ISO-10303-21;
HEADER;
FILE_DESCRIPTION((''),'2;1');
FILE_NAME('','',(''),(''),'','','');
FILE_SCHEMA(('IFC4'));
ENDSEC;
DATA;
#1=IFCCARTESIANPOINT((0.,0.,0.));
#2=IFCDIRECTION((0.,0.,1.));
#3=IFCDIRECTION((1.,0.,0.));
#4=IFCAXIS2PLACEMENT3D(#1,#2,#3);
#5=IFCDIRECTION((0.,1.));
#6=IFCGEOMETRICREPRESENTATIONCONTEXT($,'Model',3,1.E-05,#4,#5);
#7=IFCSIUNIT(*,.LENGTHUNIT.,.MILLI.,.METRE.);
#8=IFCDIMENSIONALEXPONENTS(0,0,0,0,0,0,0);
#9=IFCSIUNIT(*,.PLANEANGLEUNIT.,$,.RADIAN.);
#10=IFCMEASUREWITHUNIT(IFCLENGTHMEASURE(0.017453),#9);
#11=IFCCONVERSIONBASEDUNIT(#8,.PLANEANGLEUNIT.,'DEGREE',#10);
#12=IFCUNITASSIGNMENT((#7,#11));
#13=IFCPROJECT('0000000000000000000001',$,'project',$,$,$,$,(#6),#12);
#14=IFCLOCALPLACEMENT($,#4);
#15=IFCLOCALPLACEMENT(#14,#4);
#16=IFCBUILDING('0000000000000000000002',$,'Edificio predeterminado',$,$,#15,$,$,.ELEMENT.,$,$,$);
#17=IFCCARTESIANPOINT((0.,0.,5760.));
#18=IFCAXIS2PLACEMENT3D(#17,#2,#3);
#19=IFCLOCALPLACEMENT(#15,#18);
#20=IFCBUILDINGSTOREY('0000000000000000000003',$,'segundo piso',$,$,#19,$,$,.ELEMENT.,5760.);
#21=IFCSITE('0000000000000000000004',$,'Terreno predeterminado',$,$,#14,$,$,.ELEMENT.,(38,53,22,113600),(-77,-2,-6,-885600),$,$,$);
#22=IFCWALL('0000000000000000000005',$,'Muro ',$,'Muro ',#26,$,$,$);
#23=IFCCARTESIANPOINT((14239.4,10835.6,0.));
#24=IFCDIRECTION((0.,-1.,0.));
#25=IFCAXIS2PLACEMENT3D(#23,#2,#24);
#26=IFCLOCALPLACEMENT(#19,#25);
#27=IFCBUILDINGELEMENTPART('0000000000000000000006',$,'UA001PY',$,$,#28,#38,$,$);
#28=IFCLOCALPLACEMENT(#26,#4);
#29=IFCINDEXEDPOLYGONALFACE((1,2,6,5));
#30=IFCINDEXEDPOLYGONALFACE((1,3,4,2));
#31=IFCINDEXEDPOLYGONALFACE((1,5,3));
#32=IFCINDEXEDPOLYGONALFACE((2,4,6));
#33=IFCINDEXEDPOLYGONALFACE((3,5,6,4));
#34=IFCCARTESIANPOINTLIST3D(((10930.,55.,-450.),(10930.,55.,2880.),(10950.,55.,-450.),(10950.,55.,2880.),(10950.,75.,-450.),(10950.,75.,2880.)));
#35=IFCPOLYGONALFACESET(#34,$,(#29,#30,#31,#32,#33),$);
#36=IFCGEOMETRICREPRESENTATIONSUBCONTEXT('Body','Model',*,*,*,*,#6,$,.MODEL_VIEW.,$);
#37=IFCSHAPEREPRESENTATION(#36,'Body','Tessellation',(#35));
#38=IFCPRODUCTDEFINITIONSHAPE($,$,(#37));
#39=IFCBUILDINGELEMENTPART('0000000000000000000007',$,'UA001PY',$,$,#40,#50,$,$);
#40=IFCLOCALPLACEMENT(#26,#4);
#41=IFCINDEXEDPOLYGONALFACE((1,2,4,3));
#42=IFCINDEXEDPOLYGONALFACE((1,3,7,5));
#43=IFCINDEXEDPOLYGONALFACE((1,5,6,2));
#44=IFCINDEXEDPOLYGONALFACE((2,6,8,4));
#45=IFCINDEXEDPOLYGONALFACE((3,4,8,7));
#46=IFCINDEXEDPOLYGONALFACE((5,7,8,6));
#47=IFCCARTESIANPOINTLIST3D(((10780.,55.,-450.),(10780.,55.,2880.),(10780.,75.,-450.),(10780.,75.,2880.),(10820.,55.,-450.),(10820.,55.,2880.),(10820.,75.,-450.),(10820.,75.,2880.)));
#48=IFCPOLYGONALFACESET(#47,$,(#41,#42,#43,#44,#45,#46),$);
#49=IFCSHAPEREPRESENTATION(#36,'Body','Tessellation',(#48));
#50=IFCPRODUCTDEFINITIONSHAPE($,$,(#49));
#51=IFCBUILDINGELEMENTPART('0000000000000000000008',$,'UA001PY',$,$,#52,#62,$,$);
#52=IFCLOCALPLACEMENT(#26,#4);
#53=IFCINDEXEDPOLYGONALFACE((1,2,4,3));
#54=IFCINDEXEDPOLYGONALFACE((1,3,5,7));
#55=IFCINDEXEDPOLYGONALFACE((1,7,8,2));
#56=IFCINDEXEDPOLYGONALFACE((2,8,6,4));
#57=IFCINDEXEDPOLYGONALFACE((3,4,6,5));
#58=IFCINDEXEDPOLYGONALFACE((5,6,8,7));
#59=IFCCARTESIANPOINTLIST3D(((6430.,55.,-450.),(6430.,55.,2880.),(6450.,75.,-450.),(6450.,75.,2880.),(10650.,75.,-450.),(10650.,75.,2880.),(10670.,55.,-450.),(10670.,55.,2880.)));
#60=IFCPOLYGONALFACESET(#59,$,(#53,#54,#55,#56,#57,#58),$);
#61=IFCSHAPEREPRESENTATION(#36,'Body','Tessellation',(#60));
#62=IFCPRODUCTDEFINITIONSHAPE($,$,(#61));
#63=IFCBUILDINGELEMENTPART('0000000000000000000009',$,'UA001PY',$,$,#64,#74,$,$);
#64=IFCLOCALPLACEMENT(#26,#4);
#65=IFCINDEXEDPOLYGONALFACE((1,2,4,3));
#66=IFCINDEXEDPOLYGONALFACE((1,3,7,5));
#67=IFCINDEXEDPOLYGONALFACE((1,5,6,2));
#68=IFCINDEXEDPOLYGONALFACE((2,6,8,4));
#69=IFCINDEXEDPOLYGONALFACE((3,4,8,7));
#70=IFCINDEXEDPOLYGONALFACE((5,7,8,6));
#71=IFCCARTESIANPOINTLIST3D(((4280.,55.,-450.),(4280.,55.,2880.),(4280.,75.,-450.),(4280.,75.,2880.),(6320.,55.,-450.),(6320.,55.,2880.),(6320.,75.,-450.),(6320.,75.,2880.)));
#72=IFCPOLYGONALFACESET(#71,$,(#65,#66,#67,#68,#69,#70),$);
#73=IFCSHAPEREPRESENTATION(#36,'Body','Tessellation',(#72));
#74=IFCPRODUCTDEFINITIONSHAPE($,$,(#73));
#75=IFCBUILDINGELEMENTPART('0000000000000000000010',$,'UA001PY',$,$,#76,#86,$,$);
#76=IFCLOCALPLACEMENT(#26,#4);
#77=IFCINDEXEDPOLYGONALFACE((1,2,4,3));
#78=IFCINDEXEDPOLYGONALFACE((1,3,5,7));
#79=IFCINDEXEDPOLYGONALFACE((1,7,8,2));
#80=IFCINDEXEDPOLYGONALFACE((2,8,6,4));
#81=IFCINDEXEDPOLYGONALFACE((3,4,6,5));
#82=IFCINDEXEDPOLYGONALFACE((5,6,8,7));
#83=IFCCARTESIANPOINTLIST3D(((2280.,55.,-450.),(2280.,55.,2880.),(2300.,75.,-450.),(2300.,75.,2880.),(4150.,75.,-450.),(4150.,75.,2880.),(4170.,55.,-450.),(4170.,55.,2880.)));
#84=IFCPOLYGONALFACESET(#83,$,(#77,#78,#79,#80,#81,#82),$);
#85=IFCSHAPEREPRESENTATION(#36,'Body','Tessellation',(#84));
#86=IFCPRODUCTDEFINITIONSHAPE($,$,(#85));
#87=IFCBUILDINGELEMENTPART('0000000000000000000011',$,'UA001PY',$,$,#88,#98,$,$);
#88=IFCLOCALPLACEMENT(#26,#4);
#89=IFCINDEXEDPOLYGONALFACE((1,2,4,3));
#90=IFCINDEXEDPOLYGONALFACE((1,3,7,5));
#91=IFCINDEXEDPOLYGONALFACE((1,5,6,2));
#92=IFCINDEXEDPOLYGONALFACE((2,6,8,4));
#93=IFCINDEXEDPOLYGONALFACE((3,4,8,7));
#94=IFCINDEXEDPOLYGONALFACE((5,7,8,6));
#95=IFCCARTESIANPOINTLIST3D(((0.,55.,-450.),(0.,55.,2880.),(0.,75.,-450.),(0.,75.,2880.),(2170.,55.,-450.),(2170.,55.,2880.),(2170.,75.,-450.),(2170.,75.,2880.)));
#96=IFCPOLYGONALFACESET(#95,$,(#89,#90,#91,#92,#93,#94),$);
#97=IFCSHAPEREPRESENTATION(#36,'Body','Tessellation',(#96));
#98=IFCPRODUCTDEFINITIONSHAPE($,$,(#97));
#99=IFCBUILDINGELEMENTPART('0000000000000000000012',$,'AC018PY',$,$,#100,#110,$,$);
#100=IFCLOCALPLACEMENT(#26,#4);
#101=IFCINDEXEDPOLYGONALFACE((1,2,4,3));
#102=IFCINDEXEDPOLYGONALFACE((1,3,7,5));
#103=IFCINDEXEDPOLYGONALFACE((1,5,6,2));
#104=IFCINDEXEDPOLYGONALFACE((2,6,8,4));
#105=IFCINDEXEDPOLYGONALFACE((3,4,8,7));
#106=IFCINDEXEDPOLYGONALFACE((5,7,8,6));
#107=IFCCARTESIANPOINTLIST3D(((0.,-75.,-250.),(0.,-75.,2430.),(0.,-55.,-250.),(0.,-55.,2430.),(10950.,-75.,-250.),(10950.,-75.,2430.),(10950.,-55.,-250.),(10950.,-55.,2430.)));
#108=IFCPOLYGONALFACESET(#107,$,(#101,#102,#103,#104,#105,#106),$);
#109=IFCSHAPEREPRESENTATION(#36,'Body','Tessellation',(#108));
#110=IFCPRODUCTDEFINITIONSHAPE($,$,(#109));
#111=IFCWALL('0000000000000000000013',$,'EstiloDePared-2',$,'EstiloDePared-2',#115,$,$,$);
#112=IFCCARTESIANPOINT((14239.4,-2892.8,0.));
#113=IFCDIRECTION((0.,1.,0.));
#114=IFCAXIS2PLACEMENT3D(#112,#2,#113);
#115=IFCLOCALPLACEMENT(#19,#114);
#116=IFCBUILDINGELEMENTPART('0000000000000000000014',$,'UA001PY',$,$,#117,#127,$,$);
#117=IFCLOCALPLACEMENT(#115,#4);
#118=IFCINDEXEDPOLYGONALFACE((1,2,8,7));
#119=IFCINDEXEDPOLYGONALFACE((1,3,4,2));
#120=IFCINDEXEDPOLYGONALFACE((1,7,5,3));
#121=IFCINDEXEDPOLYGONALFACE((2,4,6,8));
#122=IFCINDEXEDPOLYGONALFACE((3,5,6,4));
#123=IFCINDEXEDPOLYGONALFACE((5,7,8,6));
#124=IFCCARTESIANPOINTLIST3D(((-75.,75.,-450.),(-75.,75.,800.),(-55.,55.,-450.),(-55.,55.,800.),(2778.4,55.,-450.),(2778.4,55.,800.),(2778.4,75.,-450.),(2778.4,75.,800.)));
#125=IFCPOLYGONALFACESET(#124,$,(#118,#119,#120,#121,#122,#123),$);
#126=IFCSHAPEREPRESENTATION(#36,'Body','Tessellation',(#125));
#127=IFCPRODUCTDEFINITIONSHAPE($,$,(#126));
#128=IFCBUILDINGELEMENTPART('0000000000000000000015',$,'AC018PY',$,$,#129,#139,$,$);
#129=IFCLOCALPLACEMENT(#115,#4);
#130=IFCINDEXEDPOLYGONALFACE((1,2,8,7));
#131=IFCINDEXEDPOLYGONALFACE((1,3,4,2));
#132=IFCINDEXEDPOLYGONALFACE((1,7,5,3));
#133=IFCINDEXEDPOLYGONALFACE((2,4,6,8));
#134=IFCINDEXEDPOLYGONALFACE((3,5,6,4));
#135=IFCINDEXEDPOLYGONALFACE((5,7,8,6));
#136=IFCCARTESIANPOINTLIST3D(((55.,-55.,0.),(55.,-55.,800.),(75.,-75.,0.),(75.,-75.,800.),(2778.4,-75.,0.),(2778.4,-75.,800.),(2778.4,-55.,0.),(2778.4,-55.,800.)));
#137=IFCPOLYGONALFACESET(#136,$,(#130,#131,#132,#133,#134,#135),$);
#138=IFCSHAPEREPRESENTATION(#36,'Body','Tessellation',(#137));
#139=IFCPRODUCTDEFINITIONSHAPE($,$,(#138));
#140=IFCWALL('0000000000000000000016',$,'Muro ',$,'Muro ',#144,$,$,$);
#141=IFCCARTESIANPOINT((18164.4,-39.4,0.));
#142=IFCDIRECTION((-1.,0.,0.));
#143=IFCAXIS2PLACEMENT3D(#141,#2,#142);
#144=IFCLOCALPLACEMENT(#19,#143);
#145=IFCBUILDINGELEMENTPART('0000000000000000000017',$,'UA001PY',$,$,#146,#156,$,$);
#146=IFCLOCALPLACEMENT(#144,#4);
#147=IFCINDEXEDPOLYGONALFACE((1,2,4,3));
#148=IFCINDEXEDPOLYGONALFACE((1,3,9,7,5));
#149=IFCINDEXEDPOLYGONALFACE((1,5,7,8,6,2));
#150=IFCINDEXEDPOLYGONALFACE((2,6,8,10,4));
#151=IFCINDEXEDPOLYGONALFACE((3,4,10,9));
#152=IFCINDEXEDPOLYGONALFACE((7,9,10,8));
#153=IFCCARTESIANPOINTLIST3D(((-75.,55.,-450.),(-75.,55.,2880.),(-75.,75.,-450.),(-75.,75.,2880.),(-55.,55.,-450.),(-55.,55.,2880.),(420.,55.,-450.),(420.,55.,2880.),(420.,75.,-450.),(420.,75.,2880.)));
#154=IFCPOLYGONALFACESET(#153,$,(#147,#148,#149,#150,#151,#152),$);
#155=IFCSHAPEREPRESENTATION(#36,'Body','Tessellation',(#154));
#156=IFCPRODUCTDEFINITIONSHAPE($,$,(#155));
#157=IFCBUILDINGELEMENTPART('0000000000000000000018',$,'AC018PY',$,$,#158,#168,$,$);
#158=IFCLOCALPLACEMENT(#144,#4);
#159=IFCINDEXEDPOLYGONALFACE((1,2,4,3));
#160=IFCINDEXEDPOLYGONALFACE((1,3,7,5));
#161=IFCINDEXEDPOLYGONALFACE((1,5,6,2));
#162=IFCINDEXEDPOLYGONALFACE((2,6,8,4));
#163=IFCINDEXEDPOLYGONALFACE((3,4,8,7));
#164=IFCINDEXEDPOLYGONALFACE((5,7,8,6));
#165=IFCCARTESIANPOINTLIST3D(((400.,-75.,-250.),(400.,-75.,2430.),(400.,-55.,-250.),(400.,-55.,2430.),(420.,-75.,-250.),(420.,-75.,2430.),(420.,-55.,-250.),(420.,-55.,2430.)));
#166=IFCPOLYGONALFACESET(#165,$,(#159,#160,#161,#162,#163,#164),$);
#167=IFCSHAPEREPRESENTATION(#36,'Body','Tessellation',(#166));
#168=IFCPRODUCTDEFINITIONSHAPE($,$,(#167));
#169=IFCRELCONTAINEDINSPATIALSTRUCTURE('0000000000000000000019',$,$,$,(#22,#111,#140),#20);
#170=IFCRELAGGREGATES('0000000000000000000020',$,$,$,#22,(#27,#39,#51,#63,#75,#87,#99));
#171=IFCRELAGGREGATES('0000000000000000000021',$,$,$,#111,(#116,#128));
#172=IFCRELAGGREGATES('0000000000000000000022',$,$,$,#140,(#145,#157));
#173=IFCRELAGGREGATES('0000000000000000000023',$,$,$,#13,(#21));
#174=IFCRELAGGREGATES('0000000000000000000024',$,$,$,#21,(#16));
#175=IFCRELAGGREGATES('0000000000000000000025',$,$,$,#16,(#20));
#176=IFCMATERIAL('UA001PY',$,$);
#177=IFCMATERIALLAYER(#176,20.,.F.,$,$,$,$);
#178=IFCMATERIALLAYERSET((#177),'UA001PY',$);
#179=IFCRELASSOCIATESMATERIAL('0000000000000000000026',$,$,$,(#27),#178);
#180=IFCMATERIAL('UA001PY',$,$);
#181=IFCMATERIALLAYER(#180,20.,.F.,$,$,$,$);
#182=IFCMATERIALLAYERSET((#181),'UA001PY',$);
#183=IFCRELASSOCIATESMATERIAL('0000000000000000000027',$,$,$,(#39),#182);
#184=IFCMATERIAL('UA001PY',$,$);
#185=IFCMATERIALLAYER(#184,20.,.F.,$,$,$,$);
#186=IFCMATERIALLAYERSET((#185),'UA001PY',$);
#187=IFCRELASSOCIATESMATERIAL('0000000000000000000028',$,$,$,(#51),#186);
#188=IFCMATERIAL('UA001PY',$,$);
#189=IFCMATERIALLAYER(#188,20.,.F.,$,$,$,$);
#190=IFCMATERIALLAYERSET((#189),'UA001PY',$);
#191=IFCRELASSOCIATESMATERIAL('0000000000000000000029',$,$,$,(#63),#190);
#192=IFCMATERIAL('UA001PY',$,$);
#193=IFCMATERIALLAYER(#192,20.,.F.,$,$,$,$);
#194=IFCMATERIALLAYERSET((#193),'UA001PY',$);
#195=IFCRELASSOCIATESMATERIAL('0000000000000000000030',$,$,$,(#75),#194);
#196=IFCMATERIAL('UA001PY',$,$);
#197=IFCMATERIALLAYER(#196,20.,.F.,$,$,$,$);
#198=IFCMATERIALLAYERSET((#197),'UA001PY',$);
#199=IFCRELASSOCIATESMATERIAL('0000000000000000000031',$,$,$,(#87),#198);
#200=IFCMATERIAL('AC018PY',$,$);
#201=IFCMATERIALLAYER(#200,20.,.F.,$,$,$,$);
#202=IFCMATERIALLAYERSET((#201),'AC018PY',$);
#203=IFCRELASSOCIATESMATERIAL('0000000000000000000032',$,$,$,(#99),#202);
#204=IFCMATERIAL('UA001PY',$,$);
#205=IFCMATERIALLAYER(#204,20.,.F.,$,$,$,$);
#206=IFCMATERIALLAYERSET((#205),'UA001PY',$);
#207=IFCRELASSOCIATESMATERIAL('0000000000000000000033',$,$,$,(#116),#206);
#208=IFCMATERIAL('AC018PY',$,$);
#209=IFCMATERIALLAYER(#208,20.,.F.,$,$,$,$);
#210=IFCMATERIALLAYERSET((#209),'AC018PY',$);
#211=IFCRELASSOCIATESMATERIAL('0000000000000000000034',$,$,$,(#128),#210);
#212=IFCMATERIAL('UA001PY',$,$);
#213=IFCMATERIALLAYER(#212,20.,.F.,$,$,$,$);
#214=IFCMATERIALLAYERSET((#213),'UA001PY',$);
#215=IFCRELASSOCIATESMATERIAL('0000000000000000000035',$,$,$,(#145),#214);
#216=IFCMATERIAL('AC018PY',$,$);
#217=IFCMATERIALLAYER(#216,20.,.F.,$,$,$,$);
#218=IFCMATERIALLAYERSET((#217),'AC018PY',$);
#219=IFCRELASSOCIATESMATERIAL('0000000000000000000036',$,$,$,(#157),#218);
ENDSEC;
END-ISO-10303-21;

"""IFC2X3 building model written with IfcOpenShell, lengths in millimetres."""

from ifc_helpers import new_model, entity, si_unit, converted_unit, direction, frame, origin_with_axes, place, context, subcontext, project, spatial, polyline, outline, extrude, material, layer, layer_set, layer_usage, element, aggregate, save


model = new_model("IFC2X3")

# Units and contexts
model_context = context("Model", 3, precision=1e-05, world=origin_with_axes(), true_north=direction((0.0, 1.0)))
body_context = subcontext(model_context, "Body", "Model", "MODEL_VIEW")
ifc_project = project(units=[si_unit("LENGTHUNIT", "METRE", prefix="MILLI"), converted_unit("PLANEANGLEUNIT", "DEGREE", entity("IfcLengthMeasure", 0.017453), si_unit("PLANEANGLEUNIT", "RADIAN"), dimensions=[0, 0, 0, 0, 0, 0, 0])], contexts=[model_context])

# Site, building, storey
site_placement = place(None, origin_with_axes())
site = spatial("IfcSite", under=ifc_project, at=site_placement, Name="Terreno predeterminado", CompositionType="ELEMENT", RefLatitude=(38, 53, 22, 113600), RefLongitude=(-77, -2, -6, -885600))
building_placement = place(site_placement, origin_with_axes())
building = spatial("IfcBuilding", under=site, at=building_placement, Name="Edificio predeterminado", CompositionType="ELEMENT")
storey_placement = place(building_placement, frame((0.0, 0.0, 5760.0), z_axis=(0.0, 0.0, 1.0), x_axis=(1.0, 0.0, 0.0)))
storey = spatial("IfcBuildingStorey", under=building, at=storey_placement, Name="segundo piso", CompositionType="ELEMENT", Elevation=5760.0)

# Walls, building element parts
wall_1_placement = place(storey_placement, frame((14239.4, 10835.6, 0.0), z_axis=(0.0, 0.0, 1.0), x_axis=(0.0, -1.0, 0.0)))
wall_1 = element("IfcWall", 1, at=wall_1_placement, inside=storey, Name="Muro ", ObjectType="Muro ")
ifc_material_1 = material(Name="UA001PY")
ifc_layer_1 = layer(ifc_material_1, 20.0, ventilated=False)
ifc_layer_set_1 = layer_set([ifc_layer_1], Name="UA001PY")
ifc_layer_usage_1 = layer_usage(ifc_layer_set_1, "AXIS2", "NEGATIVE", -75.0)
building_element_part_1_placement = place(wall_1_placement, origin_with_axes())
building_element_part_1 = element("IfcBuildingElementPart", 2, at=building_element_part_1_placement, material=ifc_layer_usage_1, Name="UA001PY", context=body_context, shape_type="SweptSolid", body=[
    extrude(outline(polyline([(10950.0, 75.0), (10950.0, 55.0), (10930.0, 55.0), (10950.0, 75.0)])), frame((0.0, 0.0, -450.0), z_axis=(0.0, 0.0, 1.0), x_axis=(1.0, 0.0, 0.0)), (0.0, 0.0, 1.0), 3330.0),
])
ifc_material_2 = material(Name="UA001PY")
ifc_layer_2 = layer(ifc_material_2, 20.0, ventilated=False)
ifc_layer_set_2 = layer_set([ifc_layer_2], Name="UA001PY")
ifc_layer_usage_2 = layer_usage(ifc_layer_set_2, "AXIS2", "NEGATIVE", -75.0)
building_element_part_2_placement = place(wall_1_placement, origin_with_axes())
building_element_part_2 = element("IfcBuildingElementPart", 3, at=building_element_part_2_placement, material=ifc_layer_usage_2, Name="UA001PY", context=body_context, shape_type="SweptSolid", body=[
    extrude(outline(polyline([(10820.0, 75.0), (10820.0, 55.0), (10780.0, 55.0), (10780.0, 75.0), (10820.0, 75.0)])), frame((0.0, 0.0, -450.0), z_axis=(0.0, 0.0, 1.0), x_axis=(1.0, 0.0, 0.0)), (0.0, 0.0, 1.0), 3330.0),
])
ifc_material_3 = material(Name="UA001PY")
ifc_layer_3 = layer(ifc_material_3, 20.0, ventilated=False)
ifc_layer_set_3 = layer_set([ifc_layer_3], Name="UA001PY")
ifc_layer_usage_3 = layer_usage(ifc_layer_set_3, "AXIS2", "NEGATIVE", -75.0)
building_element_part_3_placement = place(wall_1_placement, origin_with_axes())
building_element_part_3 = element("IfcBuildingElementPart", 4, at=building_element_part_3_placement, material=ifc_layer_usage_3, Name="UA001PY", context=body_context, shape_type="SweptSolid", body=[
    extrude(outline(polyline([(10650.0, 75.0), (10670.0, 55.0), (6430.0, 55.0), (6450.0, 75.0), (10650.0, 75.0)])), frame((0.0, 0.0, -450.0), z_axis=(0.0, 0.0, 1.0), x_axis=(1.0, 0.0, 0.0)), (0.0, 0.0, 1.0), 3330.0),
])
ifc_material_4 = material(Name="UA001PY")
ifc_layer_4 = layer(ifc_material_4, 20.0, ventilated=False)
ifc_layer_set_4 = layer_set([ifc_layer_4], Name="UA001PY")
ifc_layer_usage_4 = layer_usage(ifc_layer_set_4, "AXIS2", "NEGATIVE", -75.0)
building_element_part_4_placement = place(wall_1_placement, origin_with_axes())
building_element_part_4 = element("IfcBuildingElementPart", 5, at=building_element_part_4_placement, material=ifc_layer_usage_4, Name="UA001PY", context=body_context, shape_type="SweptSolid", body=[
    extrude(outline(polyline([(4280.0, 75.0), (6320.0, 75.0), (6320.0, 55.0), (4280.0, 55.0), (4280.0, 75.0)])), frame((0.0, 0.0, -450.0), z_axis=(0.0, 0.0, 1.0), x_axis=(1.0, 0.0, 0.0)), (0.0, 0.0, 1.0), 3330.0),
])
ifc_material_5 = material(Name="UA001PY")
ifc_layer_5 = layer(ifc_material_5, 20.0, ventilated=False)
ifc_layer_set_5 = layer_set([ifc_layer_5], Name="UA001PY")
ifc_layer_usage_5 = layer_usage(ifc_layer_set_5, "AXIS2", "NEGATIVE", -75.0)
building_element_part_5_placement = place(wall_1_placement, origin_with_axes())
building_element_part_5 = element("IfcBuildingElementPart", 6, at=building_element_part_5_placement, material=ifc_layer_usage_5, Name="UA001PY", context=body_context, shape_type="SweptSolid", body=[
    extrude(outline(polyline([(4150.0, 75.0), (4170.0, 55.0), (2280.0, 55.0), (2300.0, 75.0), (4150.0, 75.0)])), frame((0.0, 0.0, -450.0), z_axis=(0.0, 0.0, 1.0), x_axis=(1.0, 0.0, 0.0)), (0.0, 0.0, 1.0), 3330.0),
])
ifc_material_6 = material(Name="UA001PY")
ifc_layer_6 = layer(ifc_material_6, 20.0, ventilated=False)
ifc_layer_set_6 = layer_set([ifc_layer_6], Name="UA001PY")
ifc_layer_usage_6 = layer_usage(ifc_layer_set_6, "AXIS2", "NEGATIVE", -75.0)
building_element_part_6_placement = place(wall_1_placement, origin_with_axes())
building_element_part_6 = element("IfcBuildingElementPart", 7, at=building_element_part_6_placement, material=ifc_layer_usage_6, Name="UA001PY", context=body_context, shape_type="SweptSolid", body=[
    extrude(outline(polyline([(2170.0, 75.0), (2170.0, 55.0), (0.0, 55.0), (0.0, 75.0), (2170.0, 75.0)])), frame((0.0, 0.0, -450.0), z_axis=(0.0, 0.0, 1.0), x_axis=(1.0, 0.0, 0.0)), (0.0, 0.0, 1.0), 3330.0),
])
ifc_material_7 = material(Name="AC018PY")
ifc_layer_7 = layer(ifc_material_7, 20.0, ventilated=False)
ifc_layer_set_7 = layer_set([ifc_layer_7], Name="AC018PY")
ifc_layer_usage_7 = layer_usage(ifc_layer_set_7, "AXIS2", "NEGATIVE", 55.0)
building_element_part_7_placement = place(wall_1_placement, origin_with_axes())
building_element_part_7 = element("IfcBuildingElementPart", 8, at=building_element_part_7_placement, material=ifc_layer_usage_7, Name="AC018PY", context=body_context, shape_type="SweptSolid", body=[
    extrude(outline(polyline([(10950.0, -55.0), (10950.0, -75.0), (0.0, -75.0), (0.0, -55.0), (10950.0, -55.0)])), frame((0.0, 0.0, -250.0), z_axis=(0.0, 0.0, 1.0), x_axis=(1.0, 0.0, 0.0)), (0.0, 0.0, 1.0), 2680.0),
])
aggregate(wall_1, [building_element_part_1, building_element_part_2, building_element_part_3, building_element_part_4, building_element_part_5, building_element_part_6, building_element_part_7])
wall_2_placement = place(storey_placement, frame((14239.4, -2892.8, 0.0), z_axis=(0.0, 0.0, 1.0), x_axis=(0.0, 1.0, 0.0)))
wall_2 = element("IfcWall", 9, at=wall_2_placement, inside=storey, Name="EstiloDePared-2", ObjectType="EstiloDePared-2")
ifc_material_8 = material(Name="UA001PY")
ifc_layer_8 = layer(ifc_material_8, 20.0, ventilated=False)
ifc_layer_set_8 = layer_set([ifc_layer_8], Name="UA001PY")
ifc_layer_usage_8 = layer_usage(ifc_layer_set_8, "AXIS2", "NEGATIVE", -75.0)
building_element_part_8_placement = place(wall_2_placement, origin_with_axes())
building_element_part_8 = element("IfcBuildingElementPart", 10, at=building_element_part_8_placement, material=ifc_layer_usage_8, Name="UA001PY", context=body_context, shape_type="SweptSolid", body=[
    extrude(outline(polyline([(2778.4, 75.0), (2778.4, 55.0), (-55.0, 55.0), (-75.0, 75.0), (2778.4, 75.0)])), frame((0.0, 0.0, -450.0), z_axis=(0.0, 0.0, 1.0), x_axis=(1.0, 0.0, 0.0)), (0.0, 0.0, 1.0), 1250.0),
])
ifc_material_9 = material(Name="AC018PY")
ifc_layer_9 = layer(ifc_material_9, 20.0, ventilated=False)
ifc_layer_set_9 = layer_set([ifc_layer_9], Name="AC018PY")
ifc_layer_usage_9 = layer_usage(ifc_layer_set_9, "AXIS2", "NEGATIVE", 55.0)
building_element_part_9_placement = place(wall_2_placement, origin_with_axes())
building_element_part_9 = element("IfcBuildingElementPart", 11, at=building_element_part_9_placement, material=ifc_layer_usage_9, Name="AC018PY", context=body_context, shape_type="SweptSolid", body=[
    extrude(outline(polyline([(2778.4, -55.0), (2778.4, -75.0), (75.0, -75.0), (55.0, -55.0), (2778.4, -55.0)])), origin_with_axes(), (0.0, 0.0, 1.0), 800.0),
])
aggregate(wall_2, [building_element_part_8, building_element_part_9])
wall_3_placement = place(storey_placement, frame((18164.4, -39.4, 0.0), z_axis=(0.0, 0.0, 1.0), x_axis=(-1.0, 0.0, 0.0)))
wall_3 = element("IfcWall", 12, at=wall_3_placement, inside=storey, Name="Muro ", ObjectType="Muro ")
ifc_material_10 = material(Name="UA001PY")
ifc_layer_10 = layer(ifc_material_10, 20.0, ventilated=False)
ifc_layer_set_10 = layer_set([ifc_layer_10], Name="UA001PY")
ifc_layer_usage_10 = layer_usage(ifc_layer_set_10, "AXIS2", "NEGATIVE", -75.0)
building_element_part_10_placement = place(wall_3_placement, origin_with_axes())
building_element_part_10 = element("IfcBuildingElementPart", 13, at=building_element_part_10_placement, material=ifc_layer_usage_10, Name="UA001PY", context=body_context, shape_type="SweptSolid", body=[
    extrude(outline(polyline([(420.0, 75.0), (420.0, 55.0), (-55.0, 55.0), (-75.0, 55.0), (-75.0, 75.0), (420.0, 75.0)])), frame((0.0, 0.0, -450.0), z_axis=(0.0, 0.0, 1.0), x_axis=(1.0, 0.0, 0.0)), (0.0, 0.0, 1.0), 3330.0),
])
ifc_material_11 = material(Name="AC018PY")
ifc_layer_11 = layer(ifc_material_11, 20.0, ventilated=False)
ifc_layer_set_11 = layer_set([ifc_layer_11], Name="AC018PY")
ifc_layer_usage_11 = layer_usage(ifc_layer_set_11, "AXIS2", "NEGATIVE", 55.0)
building_element_part_11_placement = place(wall_3_placement, origin_with_axes())
building_element_part_11 = element("IfcBuildingElementPart", 14, at=building_element_part_11_placement, material=ifc_layer_usage_11, Name="AC018PY", context=body_context, shape_type="SweptSolid", body=[
    extrude(outline(polyline([(420.0, -55.0), (420.0, -75.0), (400.0, -75.0), (400.0, -55.0), (420.0, -55.0)])), frame((0.0, 0.0, -250.0), z_axis=(0.0, 0.0, 1.0), x_axis=(1.0, 0.0, 0.0)), (0.0, 0.0, 1.0), 2680.0),
])
aggregate(wall_3, [building_element_part_10, building_element_part_11])

save(model, "model.ifc")
